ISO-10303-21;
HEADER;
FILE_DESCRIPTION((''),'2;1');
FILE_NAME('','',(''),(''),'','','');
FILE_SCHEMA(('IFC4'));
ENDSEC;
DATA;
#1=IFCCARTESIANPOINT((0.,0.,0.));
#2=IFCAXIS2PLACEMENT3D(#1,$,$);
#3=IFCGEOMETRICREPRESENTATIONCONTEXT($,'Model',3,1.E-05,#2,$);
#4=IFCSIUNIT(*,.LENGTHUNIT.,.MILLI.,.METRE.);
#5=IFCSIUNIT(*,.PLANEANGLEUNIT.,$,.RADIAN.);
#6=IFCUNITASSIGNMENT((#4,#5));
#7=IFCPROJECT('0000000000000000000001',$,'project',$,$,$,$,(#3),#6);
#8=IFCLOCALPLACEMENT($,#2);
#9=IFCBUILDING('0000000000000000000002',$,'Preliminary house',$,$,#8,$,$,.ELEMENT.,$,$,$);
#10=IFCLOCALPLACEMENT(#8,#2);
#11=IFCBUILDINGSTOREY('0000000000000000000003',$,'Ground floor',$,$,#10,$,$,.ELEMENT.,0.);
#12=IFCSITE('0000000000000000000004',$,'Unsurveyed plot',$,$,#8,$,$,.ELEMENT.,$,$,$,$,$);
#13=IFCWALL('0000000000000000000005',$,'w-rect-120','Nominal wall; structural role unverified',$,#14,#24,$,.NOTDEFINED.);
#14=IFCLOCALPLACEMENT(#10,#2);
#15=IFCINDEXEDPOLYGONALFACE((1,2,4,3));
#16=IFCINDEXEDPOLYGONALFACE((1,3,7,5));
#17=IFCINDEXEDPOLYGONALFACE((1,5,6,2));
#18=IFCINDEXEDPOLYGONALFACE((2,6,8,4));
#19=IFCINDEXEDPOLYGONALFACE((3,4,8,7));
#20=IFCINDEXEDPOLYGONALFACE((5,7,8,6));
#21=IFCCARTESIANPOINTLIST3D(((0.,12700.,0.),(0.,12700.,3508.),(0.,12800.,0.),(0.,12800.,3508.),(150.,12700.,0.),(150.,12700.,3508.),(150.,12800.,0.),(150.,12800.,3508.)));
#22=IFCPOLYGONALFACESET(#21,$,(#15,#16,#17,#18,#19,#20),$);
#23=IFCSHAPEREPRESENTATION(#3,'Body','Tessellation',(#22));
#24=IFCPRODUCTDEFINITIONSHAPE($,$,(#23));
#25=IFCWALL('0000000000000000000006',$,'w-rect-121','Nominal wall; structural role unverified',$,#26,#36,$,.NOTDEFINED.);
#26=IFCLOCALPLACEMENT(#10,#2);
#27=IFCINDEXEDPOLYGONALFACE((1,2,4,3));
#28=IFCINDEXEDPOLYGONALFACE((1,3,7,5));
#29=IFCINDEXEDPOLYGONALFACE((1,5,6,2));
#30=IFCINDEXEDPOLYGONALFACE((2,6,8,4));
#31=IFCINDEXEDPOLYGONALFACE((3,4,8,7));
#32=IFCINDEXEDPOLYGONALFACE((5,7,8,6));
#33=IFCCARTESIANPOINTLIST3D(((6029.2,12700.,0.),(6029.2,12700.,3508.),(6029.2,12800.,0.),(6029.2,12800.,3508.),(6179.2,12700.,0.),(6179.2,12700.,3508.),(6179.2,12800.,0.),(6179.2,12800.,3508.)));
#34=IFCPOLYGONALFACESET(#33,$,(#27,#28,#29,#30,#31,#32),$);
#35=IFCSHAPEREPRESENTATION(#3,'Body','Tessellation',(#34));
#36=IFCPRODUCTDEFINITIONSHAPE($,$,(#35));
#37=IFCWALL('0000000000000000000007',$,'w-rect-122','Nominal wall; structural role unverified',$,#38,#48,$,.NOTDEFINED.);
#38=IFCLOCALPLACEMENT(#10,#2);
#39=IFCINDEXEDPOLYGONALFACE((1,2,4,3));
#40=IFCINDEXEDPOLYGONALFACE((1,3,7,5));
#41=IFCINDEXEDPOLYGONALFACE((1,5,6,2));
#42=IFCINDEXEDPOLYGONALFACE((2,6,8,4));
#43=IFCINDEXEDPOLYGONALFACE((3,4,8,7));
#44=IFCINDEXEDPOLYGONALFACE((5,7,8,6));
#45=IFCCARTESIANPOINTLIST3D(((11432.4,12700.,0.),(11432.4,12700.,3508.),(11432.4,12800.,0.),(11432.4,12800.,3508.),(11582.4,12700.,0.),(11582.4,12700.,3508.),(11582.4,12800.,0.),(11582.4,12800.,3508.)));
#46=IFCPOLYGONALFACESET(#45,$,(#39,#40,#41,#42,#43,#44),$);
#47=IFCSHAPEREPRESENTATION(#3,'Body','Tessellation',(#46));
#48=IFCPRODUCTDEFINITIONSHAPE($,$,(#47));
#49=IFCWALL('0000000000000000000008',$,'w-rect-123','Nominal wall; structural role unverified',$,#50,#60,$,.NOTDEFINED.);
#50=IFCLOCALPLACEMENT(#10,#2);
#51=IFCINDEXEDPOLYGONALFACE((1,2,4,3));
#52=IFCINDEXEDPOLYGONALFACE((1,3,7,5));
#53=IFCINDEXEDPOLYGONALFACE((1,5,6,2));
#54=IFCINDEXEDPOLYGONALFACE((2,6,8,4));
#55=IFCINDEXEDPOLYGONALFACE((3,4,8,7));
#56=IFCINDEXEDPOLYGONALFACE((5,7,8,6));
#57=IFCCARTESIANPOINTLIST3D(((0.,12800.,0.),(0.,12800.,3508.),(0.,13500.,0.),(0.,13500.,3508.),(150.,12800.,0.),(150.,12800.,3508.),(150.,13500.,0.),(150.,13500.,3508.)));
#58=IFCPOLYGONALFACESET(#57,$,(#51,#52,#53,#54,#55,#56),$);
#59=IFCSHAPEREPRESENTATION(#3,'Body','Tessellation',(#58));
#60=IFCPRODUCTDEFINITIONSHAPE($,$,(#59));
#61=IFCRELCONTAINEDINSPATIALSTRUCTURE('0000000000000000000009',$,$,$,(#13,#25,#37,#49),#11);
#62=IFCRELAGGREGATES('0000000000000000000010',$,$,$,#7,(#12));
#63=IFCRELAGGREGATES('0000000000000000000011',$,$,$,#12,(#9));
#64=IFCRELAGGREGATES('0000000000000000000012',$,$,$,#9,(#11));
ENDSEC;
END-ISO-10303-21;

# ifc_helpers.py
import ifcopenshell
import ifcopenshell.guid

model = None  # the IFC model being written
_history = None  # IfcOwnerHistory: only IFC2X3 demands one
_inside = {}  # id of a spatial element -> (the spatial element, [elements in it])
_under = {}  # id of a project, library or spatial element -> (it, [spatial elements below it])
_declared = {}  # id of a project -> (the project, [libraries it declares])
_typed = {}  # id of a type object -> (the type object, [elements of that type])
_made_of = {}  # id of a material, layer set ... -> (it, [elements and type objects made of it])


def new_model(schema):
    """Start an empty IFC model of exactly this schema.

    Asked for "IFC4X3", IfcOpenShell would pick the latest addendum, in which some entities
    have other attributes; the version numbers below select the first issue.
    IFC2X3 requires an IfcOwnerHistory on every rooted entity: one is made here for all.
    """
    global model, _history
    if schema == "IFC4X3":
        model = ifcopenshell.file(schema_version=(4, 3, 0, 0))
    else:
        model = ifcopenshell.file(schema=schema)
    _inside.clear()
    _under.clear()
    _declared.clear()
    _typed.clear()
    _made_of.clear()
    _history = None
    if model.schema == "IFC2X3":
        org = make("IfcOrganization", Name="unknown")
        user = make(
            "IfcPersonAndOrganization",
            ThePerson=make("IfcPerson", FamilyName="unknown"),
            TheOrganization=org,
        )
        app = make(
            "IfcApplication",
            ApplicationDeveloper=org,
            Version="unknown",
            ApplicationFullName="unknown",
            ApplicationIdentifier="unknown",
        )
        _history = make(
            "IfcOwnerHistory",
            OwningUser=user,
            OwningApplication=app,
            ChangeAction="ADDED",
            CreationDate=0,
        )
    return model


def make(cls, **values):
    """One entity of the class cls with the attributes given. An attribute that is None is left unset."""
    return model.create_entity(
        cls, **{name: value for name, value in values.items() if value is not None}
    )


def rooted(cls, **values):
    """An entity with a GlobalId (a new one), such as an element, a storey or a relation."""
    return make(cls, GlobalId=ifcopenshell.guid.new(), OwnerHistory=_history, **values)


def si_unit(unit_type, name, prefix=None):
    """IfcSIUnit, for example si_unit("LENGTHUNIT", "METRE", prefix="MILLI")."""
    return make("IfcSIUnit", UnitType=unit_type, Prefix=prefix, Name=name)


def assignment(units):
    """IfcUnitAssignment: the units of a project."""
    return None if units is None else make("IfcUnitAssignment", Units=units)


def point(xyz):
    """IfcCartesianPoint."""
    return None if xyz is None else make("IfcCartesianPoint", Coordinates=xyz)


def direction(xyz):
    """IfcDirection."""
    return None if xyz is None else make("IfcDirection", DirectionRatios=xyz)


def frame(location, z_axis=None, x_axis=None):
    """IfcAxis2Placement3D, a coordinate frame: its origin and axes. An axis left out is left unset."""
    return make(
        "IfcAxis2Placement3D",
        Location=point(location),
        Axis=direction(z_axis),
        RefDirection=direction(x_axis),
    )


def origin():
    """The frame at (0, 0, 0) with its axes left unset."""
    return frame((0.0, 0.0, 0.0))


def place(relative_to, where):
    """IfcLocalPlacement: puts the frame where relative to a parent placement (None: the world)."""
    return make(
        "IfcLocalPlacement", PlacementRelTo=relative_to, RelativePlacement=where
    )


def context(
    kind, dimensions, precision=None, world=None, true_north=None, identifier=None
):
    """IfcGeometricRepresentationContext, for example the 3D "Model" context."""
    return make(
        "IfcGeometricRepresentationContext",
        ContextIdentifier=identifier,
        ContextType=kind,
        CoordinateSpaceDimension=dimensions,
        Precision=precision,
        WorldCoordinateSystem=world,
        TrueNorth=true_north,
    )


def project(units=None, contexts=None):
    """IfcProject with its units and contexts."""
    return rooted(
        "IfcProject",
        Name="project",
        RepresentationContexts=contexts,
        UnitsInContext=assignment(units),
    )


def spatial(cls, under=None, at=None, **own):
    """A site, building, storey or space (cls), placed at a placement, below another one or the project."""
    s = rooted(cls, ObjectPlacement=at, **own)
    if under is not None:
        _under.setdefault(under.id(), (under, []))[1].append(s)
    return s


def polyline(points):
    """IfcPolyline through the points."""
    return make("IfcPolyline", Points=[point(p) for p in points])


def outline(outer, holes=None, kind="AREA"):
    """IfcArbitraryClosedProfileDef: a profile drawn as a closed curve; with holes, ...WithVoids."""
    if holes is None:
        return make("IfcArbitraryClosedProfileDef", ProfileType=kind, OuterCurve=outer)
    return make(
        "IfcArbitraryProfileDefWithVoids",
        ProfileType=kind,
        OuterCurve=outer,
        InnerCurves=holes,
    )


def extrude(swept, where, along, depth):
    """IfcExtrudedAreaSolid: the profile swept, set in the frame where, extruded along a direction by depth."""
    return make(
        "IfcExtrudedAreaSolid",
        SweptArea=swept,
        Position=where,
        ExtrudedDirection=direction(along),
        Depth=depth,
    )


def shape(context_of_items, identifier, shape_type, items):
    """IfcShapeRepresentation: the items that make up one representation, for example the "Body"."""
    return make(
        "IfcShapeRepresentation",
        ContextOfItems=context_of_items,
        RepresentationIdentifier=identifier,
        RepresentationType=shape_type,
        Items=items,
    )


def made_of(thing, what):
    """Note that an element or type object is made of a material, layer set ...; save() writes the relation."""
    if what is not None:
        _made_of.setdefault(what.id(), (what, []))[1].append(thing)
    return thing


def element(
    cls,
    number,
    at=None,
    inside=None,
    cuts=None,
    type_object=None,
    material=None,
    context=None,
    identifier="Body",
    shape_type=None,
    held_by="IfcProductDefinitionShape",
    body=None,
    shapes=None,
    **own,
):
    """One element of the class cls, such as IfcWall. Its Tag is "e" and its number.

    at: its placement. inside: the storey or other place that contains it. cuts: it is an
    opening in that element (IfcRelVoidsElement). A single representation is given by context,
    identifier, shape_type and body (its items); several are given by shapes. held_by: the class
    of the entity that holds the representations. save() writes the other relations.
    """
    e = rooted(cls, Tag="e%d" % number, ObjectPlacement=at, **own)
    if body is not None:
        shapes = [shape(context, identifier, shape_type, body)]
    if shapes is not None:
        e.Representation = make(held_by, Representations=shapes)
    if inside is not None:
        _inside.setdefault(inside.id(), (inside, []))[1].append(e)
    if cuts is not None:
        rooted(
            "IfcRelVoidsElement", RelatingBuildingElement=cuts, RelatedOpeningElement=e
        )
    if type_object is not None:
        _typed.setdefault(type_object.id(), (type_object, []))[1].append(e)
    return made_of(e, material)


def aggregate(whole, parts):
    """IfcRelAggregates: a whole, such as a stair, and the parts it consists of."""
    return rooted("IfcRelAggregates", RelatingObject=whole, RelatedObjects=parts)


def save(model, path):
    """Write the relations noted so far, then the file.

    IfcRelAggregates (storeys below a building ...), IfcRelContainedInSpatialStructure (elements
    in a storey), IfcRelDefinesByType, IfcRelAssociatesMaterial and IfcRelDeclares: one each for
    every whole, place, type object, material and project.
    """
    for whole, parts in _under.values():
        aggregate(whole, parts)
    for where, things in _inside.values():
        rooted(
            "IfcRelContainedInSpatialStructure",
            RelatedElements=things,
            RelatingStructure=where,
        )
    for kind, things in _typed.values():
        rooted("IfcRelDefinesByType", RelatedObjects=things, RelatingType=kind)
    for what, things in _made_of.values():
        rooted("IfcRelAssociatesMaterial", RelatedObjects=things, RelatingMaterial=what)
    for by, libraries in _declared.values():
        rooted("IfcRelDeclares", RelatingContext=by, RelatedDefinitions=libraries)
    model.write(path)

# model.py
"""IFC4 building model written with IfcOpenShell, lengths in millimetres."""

from ifc_helpers import new_model, si_unit, origin, place, context, project, spatial, polyline, outline, extrude, element, save


model = new_model("IFC4")

# Units and contexts
model_context = context("Model", 3, precision=1e-05, world=origin())
ifc_project = project(units=[si_unit("LENGTHUNIT", "METRE", prefix="MILLI"), si_unit("PLANEANGLEUNIT", "RADIAN")], contexts=[model_context])

# Site, building, storey
placement_1 = place(None, origin())
site = spatial("IfcSite", under=ifc_project, at=placement_1, Name="Unsurveyed plot", CompositionType="ELEMENT")
building = spatial("IfcBuilding", under=site, at=placement_1, Name="Preliminary house", CompositionType="ELEMENT")
placement_2 = place(placement_1, origin())
storey = spatial("IfcBuildingStorey", under=building, at=placement_2, Name="Ground floor", CompositionType="ELEMENT", Elevation=0.0)

# Walls
element("IfcWall", 1, at=placement_2, inside=storey, Name="w-rect-120", Description="Nominal wall; structural role unverified", PredefinedType="NOTDEFINED", context=model_context, shape_type="SweptSolid", body=[
    extrude(outline(polyline([(0.0, 12700.0), (150.0, 12700.0), (150.0, 12800.0), (0.0, 12800.0), (0.0, 12700.0)])), origin(), (0.0, 0.0, 1.0), 3508.0),
])
element("IfcWall", 2, at=placement_2, inside=storey, Name="w-rect-121", Description="Nominal wall; structural role unverified", PredefinedType="NOTDEFINED", context=model_context, shape_type="SweptSolid", body=[
    extrude(outline(polyline([(6029.2, 12700.0), (6179.2, 12700.0), (6179.2, 12800.0), (6029.2, 12800.0), (6029.2, 12700.0)])), origin(), (0.0, 0.0, 1.0), 3508.0),
])
element("IfcWall", 3, at=placement_2, inside=storey, Name="w-rect-122", Description="Nominal wall; structural role unverified", PredefinedType="NOTDEFINED", context=model_context, shape_type="SweptSolid", body=[
    extrude(outline(polyline([(11432.4, 12700.0), (11582.4, 12700.0), (11582.4, 12800.0), (11432.4, 12800.0), (11432.4, 12700.0)])), origin(), (0.0, 0.0, 1.0), 3508.0),
])
element("IfcWall", 4, at=placement_2, inside=storey, Name="w-rect-123", Description="Nominal wall; structural role unverified", PredefinedType="NOTDEFINED", context=model_context, shape_type="SweptSolid", body=[
    extrude(outline(polyline([(0.0, 12800.0), (150.0, 12800.0), (150.0, 13500.0), (0.0, 13500.0), (0.0, 12800.0)])), origin(), (0.0, 0.0, 1.0), 3508.0),
])

save(model, "model.ifc")
